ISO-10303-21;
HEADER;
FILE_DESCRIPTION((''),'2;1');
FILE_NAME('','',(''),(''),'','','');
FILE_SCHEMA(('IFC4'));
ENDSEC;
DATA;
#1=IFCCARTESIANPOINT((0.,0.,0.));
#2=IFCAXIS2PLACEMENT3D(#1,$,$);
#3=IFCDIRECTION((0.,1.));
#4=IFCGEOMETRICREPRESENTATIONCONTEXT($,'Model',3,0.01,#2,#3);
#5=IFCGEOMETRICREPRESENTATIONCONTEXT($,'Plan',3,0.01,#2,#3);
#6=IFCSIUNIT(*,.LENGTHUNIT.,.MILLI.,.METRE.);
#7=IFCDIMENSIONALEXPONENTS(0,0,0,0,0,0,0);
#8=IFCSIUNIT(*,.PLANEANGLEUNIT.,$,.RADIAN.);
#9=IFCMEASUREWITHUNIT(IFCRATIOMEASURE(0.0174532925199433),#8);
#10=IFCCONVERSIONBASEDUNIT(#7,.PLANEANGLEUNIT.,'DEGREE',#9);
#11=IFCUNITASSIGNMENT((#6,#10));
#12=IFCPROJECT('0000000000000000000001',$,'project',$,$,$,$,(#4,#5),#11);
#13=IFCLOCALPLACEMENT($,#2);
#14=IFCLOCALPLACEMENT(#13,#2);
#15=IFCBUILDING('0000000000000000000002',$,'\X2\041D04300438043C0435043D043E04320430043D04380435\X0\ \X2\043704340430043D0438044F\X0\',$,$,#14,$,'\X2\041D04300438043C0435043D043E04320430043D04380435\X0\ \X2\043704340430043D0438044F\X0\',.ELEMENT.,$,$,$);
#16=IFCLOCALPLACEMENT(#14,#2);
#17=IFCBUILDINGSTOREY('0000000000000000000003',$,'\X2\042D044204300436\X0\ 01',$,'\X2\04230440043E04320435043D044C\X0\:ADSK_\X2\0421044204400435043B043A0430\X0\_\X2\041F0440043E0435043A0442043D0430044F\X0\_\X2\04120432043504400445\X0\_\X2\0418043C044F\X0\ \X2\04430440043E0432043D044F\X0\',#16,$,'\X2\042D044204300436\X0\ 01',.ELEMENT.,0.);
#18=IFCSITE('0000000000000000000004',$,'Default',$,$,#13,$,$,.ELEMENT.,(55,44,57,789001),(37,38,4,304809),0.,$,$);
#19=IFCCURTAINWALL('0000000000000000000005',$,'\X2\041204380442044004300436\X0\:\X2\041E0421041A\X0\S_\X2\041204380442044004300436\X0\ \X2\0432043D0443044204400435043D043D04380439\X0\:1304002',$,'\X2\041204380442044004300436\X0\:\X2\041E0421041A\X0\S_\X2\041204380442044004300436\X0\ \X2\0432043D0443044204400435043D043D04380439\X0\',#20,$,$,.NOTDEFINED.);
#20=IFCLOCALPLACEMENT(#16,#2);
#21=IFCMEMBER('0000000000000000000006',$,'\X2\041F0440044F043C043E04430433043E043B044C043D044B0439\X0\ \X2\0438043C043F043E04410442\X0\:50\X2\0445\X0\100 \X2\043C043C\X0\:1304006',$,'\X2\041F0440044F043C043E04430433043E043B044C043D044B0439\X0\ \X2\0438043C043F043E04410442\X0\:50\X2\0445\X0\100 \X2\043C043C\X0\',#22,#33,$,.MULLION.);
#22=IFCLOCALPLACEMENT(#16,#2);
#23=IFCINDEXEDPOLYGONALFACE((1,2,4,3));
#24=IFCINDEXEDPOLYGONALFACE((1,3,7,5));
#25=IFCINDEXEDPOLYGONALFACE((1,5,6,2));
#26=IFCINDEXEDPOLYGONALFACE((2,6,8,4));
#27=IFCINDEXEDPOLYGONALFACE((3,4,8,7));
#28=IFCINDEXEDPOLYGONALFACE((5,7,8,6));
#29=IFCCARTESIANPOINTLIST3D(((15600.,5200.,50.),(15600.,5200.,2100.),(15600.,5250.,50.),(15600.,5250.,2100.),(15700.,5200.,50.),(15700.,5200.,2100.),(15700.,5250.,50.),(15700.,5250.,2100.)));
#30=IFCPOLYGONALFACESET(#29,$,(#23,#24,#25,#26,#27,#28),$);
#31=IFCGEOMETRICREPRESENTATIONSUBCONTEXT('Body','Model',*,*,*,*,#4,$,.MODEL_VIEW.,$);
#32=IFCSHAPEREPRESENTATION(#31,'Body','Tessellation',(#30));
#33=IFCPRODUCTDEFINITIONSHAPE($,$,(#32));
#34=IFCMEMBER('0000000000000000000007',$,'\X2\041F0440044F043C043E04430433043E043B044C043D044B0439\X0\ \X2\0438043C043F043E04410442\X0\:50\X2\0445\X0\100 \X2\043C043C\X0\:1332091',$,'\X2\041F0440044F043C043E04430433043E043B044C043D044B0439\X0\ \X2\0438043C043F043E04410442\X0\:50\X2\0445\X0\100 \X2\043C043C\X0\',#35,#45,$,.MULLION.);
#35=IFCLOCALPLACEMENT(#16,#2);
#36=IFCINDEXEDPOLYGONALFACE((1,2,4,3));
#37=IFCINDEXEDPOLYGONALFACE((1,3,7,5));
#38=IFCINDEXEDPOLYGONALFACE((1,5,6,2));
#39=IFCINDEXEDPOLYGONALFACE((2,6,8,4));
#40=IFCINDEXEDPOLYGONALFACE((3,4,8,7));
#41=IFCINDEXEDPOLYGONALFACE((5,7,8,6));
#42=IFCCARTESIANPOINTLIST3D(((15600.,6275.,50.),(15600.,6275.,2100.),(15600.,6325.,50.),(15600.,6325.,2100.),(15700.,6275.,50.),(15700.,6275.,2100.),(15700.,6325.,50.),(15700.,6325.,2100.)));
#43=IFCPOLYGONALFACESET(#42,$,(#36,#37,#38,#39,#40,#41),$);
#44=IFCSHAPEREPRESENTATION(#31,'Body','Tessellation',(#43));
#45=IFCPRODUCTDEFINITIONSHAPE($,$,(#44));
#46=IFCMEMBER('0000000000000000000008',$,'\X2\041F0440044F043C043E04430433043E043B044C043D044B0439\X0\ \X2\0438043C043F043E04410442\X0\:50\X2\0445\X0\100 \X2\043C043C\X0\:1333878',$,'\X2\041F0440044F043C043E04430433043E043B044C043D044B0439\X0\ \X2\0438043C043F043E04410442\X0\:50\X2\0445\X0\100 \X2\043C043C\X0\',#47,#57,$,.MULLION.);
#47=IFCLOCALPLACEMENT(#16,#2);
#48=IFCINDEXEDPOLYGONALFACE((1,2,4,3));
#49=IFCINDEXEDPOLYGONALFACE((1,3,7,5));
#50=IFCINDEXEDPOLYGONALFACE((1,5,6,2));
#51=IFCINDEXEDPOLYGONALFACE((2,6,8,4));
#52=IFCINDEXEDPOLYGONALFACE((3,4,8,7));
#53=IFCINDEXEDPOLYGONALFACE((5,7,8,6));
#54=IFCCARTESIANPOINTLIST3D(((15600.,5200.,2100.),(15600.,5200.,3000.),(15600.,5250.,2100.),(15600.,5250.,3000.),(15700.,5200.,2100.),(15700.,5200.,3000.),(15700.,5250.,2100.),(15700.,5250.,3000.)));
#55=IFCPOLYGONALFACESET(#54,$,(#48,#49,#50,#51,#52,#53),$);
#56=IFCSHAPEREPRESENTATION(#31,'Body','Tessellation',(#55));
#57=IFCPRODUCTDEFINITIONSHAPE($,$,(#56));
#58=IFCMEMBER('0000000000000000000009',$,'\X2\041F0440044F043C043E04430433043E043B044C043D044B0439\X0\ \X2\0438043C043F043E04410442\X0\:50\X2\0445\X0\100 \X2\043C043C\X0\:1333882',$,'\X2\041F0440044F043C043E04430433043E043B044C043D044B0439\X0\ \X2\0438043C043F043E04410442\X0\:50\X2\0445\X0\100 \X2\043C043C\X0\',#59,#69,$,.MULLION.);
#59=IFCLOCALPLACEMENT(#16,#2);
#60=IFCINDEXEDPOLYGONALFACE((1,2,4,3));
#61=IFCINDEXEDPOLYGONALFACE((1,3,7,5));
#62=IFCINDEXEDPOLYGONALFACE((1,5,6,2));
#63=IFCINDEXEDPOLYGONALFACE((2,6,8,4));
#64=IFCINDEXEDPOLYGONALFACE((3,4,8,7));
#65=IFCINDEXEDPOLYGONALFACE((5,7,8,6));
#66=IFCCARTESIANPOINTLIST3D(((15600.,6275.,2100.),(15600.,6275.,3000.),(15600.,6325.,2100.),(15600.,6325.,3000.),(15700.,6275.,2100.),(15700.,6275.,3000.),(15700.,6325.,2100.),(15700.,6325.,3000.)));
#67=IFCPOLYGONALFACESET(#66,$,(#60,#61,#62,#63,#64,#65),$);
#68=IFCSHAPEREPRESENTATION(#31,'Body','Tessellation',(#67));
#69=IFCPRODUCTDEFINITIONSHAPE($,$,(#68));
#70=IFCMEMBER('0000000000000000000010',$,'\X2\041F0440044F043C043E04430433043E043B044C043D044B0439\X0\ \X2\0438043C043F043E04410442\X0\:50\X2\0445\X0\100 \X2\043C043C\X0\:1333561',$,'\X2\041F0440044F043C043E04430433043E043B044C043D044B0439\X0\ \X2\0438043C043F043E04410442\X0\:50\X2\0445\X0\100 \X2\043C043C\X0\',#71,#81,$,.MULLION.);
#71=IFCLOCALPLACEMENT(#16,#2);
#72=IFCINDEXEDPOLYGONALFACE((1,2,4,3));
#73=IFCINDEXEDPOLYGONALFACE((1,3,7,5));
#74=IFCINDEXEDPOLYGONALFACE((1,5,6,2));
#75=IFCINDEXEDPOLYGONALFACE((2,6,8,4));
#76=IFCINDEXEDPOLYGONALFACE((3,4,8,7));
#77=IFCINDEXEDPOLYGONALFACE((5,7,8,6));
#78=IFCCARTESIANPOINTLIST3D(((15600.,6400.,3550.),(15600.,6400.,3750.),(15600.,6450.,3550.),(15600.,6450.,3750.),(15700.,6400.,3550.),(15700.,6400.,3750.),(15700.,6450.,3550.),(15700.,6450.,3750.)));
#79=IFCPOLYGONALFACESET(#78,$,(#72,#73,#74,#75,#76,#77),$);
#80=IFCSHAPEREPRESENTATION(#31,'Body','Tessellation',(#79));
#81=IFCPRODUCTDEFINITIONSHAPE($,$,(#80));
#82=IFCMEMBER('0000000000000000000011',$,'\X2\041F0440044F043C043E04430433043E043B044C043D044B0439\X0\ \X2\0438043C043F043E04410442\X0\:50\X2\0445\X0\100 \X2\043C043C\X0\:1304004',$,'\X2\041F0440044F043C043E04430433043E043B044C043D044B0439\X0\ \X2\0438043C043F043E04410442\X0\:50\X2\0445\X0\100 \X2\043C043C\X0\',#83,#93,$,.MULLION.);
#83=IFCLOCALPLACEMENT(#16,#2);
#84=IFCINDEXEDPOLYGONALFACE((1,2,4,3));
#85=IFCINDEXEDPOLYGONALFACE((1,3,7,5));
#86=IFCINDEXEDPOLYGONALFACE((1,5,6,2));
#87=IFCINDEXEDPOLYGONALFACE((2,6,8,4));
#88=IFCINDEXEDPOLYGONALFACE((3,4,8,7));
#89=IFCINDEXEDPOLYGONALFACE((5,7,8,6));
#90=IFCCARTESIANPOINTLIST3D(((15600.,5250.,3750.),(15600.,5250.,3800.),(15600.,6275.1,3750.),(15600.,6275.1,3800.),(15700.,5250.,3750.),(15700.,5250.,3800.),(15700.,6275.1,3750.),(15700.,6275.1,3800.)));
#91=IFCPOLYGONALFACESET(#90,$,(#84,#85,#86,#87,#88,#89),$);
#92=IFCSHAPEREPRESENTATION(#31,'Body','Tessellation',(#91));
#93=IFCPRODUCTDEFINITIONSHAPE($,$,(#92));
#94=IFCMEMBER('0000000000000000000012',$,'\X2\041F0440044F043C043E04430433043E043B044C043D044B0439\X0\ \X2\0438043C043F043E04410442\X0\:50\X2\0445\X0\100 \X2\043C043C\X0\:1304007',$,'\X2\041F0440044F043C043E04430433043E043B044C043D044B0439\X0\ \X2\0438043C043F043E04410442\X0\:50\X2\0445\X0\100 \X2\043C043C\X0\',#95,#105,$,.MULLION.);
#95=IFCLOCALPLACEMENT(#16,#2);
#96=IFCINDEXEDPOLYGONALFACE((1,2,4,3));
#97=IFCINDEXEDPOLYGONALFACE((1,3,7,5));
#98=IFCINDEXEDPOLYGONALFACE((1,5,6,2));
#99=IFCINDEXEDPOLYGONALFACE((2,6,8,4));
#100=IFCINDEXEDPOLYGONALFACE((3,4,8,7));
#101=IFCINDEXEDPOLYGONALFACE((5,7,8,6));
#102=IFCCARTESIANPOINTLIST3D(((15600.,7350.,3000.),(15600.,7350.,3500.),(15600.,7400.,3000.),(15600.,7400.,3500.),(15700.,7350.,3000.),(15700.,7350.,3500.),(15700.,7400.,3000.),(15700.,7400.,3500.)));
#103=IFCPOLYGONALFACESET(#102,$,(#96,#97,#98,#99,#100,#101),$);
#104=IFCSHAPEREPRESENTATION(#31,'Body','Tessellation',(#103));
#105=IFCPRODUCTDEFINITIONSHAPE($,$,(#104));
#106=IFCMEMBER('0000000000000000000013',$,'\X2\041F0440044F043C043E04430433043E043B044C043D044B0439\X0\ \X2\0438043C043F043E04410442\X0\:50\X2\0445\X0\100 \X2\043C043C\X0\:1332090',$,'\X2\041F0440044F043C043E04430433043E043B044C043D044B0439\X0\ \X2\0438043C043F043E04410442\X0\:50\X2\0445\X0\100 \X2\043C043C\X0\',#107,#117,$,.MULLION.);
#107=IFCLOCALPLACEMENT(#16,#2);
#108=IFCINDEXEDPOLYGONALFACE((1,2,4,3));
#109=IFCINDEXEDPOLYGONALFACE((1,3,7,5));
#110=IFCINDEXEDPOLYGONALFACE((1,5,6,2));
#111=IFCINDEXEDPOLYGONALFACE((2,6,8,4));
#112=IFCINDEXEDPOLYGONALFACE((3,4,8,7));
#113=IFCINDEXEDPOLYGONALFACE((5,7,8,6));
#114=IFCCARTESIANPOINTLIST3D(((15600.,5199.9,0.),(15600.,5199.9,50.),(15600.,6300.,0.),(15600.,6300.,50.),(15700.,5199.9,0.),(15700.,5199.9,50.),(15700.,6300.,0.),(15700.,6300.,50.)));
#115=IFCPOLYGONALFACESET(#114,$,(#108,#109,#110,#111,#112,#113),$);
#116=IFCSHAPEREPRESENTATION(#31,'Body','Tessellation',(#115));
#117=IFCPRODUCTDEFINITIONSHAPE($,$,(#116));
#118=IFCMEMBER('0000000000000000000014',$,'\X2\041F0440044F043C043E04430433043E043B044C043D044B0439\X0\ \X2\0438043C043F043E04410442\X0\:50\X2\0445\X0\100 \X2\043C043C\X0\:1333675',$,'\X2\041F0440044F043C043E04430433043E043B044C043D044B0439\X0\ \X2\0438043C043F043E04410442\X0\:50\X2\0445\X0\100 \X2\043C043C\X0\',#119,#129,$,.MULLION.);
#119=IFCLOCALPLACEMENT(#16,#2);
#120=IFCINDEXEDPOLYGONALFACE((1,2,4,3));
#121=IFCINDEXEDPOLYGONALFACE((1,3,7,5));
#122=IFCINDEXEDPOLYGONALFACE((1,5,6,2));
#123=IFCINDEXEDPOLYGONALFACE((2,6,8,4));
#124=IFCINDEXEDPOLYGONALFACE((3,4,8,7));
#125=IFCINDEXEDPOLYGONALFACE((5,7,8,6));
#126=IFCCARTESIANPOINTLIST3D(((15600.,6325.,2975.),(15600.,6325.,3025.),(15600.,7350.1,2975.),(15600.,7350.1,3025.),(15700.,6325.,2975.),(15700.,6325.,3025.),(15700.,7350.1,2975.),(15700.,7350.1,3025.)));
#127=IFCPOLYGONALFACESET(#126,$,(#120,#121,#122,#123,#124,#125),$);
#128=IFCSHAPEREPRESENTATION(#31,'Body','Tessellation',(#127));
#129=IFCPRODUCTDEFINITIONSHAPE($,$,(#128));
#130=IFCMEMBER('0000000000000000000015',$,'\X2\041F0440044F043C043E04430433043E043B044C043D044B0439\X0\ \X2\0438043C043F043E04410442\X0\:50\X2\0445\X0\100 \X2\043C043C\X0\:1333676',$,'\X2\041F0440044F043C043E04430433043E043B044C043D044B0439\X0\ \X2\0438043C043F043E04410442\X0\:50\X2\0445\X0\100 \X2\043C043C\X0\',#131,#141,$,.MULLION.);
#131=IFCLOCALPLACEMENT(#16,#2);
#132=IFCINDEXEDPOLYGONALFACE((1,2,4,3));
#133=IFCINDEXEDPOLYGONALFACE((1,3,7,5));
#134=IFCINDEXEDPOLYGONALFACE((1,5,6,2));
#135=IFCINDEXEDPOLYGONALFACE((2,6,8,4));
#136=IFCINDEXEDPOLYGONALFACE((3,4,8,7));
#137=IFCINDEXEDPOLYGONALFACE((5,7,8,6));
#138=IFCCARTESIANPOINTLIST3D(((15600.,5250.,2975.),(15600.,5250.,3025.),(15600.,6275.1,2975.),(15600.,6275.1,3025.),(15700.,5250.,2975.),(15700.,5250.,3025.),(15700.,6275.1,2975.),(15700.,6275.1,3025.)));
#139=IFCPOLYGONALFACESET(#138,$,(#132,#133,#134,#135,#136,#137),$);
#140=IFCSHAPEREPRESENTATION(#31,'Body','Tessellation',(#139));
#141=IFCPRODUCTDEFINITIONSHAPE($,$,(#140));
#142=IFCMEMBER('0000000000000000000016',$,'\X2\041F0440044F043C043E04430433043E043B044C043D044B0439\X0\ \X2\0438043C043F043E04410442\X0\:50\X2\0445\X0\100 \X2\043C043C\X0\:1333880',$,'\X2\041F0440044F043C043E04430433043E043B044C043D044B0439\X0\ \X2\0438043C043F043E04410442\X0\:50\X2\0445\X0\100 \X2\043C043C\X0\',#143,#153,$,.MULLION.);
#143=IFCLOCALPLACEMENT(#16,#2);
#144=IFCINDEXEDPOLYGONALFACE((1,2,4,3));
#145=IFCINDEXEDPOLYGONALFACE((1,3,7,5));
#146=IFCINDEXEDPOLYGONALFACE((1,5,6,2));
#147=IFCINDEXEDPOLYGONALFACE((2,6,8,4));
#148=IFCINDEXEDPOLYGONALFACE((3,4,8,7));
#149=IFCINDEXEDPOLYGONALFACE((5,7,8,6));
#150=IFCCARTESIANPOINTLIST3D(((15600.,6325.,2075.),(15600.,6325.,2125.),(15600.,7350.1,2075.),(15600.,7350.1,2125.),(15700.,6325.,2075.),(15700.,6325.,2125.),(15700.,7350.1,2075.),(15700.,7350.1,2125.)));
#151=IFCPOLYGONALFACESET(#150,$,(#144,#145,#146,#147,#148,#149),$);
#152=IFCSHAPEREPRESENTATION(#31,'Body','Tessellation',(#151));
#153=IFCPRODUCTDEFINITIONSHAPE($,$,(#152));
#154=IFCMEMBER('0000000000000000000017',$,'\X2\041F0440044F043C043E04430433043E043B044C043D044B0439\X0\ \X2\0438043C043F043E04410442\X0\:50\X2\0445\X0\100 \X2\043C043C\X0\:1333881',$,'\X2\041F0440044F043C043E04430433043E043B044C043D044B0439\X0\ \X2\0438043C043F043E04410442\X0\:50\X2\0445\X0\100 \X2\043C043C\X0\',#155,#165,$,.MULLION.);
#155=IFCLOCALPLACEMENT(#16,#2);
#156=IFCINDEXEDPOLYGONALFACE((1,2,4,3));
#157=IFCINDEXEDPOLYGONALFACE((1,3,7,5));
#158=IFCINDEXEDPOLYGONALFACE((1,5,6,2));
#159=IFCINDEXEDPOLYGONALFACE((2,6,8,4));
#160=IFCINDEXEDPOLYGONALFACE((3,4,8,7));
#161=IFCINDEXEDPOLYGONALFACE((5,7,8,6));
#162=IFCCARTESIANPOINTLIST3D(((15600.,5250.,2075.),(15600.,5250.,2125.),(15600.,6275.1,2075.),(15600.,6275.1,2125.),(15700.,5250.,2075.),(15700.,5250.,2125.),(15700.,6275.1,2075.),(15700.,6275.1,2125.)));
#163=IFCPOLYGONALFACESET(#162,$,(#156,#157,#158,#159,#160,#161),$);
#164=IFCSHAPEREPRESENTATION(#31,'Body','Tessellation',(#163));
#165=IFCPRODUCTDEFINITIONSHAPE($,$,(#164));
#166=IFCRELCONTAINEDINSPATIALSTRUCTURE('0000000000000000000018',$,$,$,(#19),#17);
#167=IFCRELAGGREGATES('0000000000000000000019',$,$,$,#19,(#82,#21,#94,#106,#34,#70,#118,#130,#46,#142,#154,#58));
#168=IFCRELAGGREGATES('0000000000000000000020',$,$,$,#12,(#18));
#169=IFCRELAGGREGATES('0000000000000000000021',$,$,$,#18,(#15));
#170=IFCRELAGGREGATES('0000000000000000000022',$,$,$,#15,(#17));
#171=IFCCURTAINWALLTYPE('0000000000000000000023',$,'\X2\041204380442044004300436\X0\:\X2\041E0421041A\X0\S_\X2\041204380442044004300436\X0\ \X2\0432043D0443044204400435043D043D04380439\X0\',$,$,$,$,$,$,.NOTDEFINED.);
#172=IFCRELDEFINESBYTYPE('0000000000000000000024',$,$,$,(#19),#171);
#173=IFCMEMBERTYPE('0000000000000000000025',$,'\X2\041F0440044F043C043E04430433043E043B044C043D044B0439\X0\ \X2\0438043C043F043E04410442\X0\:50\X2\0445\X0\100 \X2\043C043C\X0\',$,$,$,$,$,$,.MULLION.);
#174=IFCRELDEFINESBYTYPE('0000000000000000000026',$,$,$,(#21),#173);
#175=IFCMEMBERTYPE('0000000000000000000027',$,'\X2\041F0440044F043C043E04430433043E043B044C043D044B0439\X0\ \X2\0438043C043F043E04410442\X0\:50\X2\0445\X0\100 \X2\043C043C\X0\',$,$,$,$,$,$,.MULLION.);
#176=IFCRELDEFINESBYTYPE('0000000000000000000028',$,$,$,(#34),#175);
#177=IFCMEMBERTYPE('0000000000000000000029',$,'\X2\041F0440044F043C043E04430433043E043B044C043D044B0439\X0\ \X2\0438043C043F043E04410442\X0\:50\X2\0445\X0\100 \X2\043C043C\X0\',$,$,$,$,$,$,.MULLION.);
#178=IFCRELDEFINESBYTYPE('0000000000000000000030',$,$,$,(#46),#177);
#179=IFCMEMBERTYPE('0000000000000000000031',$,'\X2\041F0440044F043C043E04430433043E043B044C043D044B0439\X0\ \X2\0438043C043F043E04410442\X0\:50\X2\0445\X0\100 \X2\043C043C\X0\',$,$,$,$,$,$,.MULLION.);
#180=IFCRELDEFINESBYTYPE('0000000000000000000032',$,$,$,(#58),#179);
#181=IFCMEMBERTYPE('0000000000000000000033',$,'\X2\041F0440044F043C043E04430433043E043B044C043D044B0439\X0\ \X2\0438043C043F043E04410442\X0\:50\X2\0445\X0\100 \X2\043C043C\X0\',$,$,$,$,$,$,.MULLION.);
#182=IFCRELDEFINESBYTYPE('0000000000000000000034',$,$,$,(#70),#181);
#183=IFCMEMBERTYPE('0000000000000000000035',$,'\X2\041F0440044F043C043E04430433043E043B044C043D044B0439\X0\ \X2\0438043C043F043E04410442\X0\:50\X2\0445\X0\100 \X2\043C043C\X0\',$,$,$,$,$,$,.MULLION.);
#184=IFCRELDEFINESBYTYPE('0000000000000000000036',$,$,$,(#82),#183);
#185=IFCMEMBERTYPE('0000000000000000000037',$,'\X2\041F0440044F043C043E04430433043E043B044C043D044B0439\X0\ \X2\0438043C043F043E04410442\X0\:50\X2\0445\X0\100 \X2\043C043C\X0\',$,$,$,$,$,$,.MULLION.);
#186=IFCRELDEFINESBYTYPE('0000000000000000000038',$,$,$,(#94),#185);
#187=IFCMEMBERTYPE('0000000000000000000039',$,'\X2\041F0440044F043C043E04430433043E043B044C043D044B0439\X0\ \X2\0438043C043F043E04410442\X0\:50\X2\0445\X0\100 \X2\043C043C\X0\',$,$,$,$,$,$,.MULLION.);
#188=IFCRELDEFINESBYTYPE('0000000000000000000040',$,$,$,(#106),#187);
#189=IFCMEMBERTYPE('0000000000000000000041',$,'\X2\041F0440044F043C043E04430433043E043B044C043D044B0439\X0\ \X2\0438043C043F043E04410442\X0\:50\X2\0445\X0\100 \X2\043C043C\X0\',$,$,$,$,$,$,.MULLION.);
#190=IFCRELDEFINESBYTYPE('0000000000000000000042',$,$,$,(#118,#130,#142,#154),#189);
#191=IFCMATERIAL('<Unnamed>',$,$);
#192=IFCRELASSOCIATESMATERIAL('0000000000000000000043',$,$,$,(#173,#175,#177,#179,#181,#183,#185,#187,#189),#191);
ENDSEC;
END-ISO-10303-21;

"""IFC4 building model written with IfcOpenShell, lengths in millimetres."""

from ifc_helpers import new_model, entity, si_unit, converted_unit, direction, frame, origin, place, context, subcontext, project, spatial, indexed_curve, outline, extrude, source, transform, mapped, material, type_object, type_shapes, element, aggregate, save


model = new_model("IFC4")

# Units and contexts
model_context = context("Model", 3, precision=0.01, world=origin(), true_north=direction((0.0, 1.0)))
plan_context = context("Plan", 3, precision=0.01, world=origin(), true_north=direction((0.0, 1.0)))
body_context = subcontext(model_context, "Body", "Model", "MODEL_VIEW")
ifc_project = project(units=[si_unit("LENGTHUNIT", "METRE", prefix="MILLI"), converted_unit("PLANEANGLEUNIT", "DEGREE", entity("IfcRatioMeasure", 0.0174532925199433), si_unit("PLANEANGLEUNIT", "RADIAN"), dimensions=[0, 0, 0, 0, 0, 0, 0])], contexts=[model_context, plan_context])

# Site, building, storey
site_placement = place(None, frame((0.0, 0.0, 0.0)))
site = spatial("IfcSite", under=ifc_project, at=site_placement, Name="Default", CompositionType="ELEMENT", RefLatitude=(55, 44, 57, 789001), RefLongitude=(37, 38, 4, 304809), RefElevation=0.0)
building_placement = place(site_placement, origin())
building = spatial("IfcBuilding", under=site, at=building_placement, Name="Наименование здания", LongName="Наименование здания", CompositionType="ELEMENT")
storey_placement = place(building_placement, origin())
storey = spatial("IfcBuildingStorey", under=building, at=storey_placement, Name="Этаж 01", ObjectType="Уровень:ADSK_Стрелка_Проектная_Вверх_Имя уровня", LongName="Этаж 01", CompositionType="ELEMENT", Elevation=0.0)

# Curtain wall, members
curtain_wall_type = type_object("IfcCurtainWallType", Name="Витраж:ОСКS_Витраж внутренний", PredefinedType="NOTDEFINED")
curtain_wall_placement = place(storey_placement, origin())
curtain_wall = element("IfcCurtainWall", 1, at=curtain_wall_placement, inside=storey, type_object=curtain_wall_type, Name="Витраж:ОСКS_Витраж внутренний:1304002", ObjectType="Витраж:ОСКS_Витраж внутренний", PredefinedType="NOTDEFINED")
ifc_material_1 = material(Name="<Unnamed>")
member_type_1 = type_object("IfcMemberType", Name="Прямоугольный импост:50х100 мм", PredefinedType="MULLION", material=ifc_material_1)
shared_shape_1 = source(origin(), body_context, "Body", "SweptSolid", [
    extrude(outline(indexed_curve([(-50.0, -25.0), (50.0, -25.0), (50.0, 25.0), (-50.0, 25.0), (-50.0, -25.0)], self_intersect=False)), frame((-25.0, 0.0, -2050.0), z_axis=(0.0, 0.0, 1.0), x_axis=(0.0, -1.0, 0.0)), (0.0, 0.0, 1.0), 2050.0),
])
type_shapes(member_type_1, [shared_shape_1])
member_1_placement = place(storey_placement, frame((15650.0, 5200.0, 50.0), z_axis=(0.0, 0.0, -1.0), x_axis=(0.0, -1.0, 0.0)))
member_1 = element("IfcMember", 2, at=member_1_placement, type_object=member_type_1, Name="Прямоугольный импост:50х100 мм:1304006", ObjectType="Прямоугольный импост:50х100 мм", PredefinedType="MULLION", context=body_context, shape_type="MappedRepresentation", body=[
    mapped(shared_shape_1, transform((0.0, 0.0, 0.0), scale=1.0)),
])
member_type_2 = type_object("IfcMemberType", Name="Прямоугольный импост:50х100 мм", PredefinedType="MULLION", material=ifc_material_1)
shared_shape_2 = source(origin(), body_context, "Body", "SweptSolid", [
    extrude(outline(indexed_curve([(-50.0, -25.0), (50.0, -25.0), (50.0, 25.0), (-50.0, 25.0), (-50.0, -25.0)], self_intersect=False)), frame((0.0, 0.0, -2050.0), z_axis=(0.0, 0.0, 1.0), x_axis=(0.0, -1.0, 0.0)), (0.0, 0.0, 1.0), 2050.0),
])
type_shapes(member_type_2, [shared_shape_2])
member_2_placement = place(storey_placement, frame((15650.0, 6300.0, 50.0), z_axis=(0.0, 0.0, -1.0), x_axis=(0.0, -1.0, 0.0)))
member_2 = element("IfcMember", 3, at=member_2_placement, type_object=member_type_2, Name="Прямоугольный импост:50х100 мм:1332091", ObjectType="Прямоугольный импост:50х100 мм", PredefinedType="MULLION", context=body_context, shape_type="MappedRepresentation", body=[
    mapped(shared_shape_2, transform((0.0, 0.0, 0.0), scale=1.0)),
])
member_type_3 = type_object("IfcMemberType", Name="Прямоугольный импост:50х100 мм", PredefinedType="MULLION", material=ifc_material_1)
shared_shape_3 = source(origin(), body_context, "Body", "SweptSolid", [
    extrude(outline(indexed_curve([(-50.0, -25.0), (50.0, -25.0), (50.0, 25.0), (-50.0, 25.0), (-50.0, -25.0)], self_intersect=False)), frame((-25.0, 0.0, -900.0), z_axis=(0.0, 0.0, 1.0), x_axis=(0.0, -1.0, 0.0)), (0.0, 0.0, 1.0), 900.0),
])
type_shapes(member_type_3, [shared_shape_3])
member_3_placement = place(storey_placement, frame((15650.0, 5200.0, 2100.0), z_axis=(0.0, 0.0, -1.0), x_axis=(0.0, -1.0, 0.0)))
member_3 = element("IfcMember", 4, at=member_3_placement, type_object=member_type_3, Name="Прямоугольный импост:50х100 мм:1333878", ObjectType="Прямоугольный импост:50х100 мм", PredefinedType="MULLION", context=body_context, shape_type="MappedRepresentation", body=[
    mapped(shared_shape_3, transform((0.0, 0.0, 0.0), scale=1.0)),
])
member_type_4 = type_object("IfcMemberType", Name="Прямоугольный импост:50х100 мм", PredefinedType="MULLION", material=ifc_material_1)
shared_shape_4 = source(origin(), body_context, "Body", "SweptSolid", [
    extrude(outline(indexed_curve([(-50.0, -25.0), (50.0, -25.0), (50.0, 25.0), (-50.0, 25.0), (-50.0, -25.0)], self_intersect=False)), frame((0.0, 0.0, -900.0), z_axis=(0.0, 0.0, 1.0), x_axis=(0.0, -1.0, 0.0)), (0.0, 0.0, 1.0), 900.0),
])
type_shapes(member_type_4, [shared_shape_4])
member_4_placement = place(storey_placement, frame((15650.0, 6300.0, 2100.0), z_axis=(0.0, 0.0, -1.0), x_axis=(0.0, -1.0, 0.0)))
member_4 = element("IfcMember", 5, at=member_4_placement, type_object=member_type_4, Name="Прямоугольный импост:50х100 мм:1333882", ObjectType="Прямоугольный импост:50х100 мм", PredefinedType="MULLION", context=body_context, shape_type="MappedRepresentation", body=[
    mapped(shared_shape_4, transform((0.0, 0.0, 0.0), scale=1.0)),
])
member_type_5 = type_object("IfcMemberType", Name="Прямоугольный импост:50х100 мм", PredefinedType="MULLION", material=ifc_material_1)
shared_shape_5 = source(origin(), body_context, "Body", "SweptSolid", [
    extrude(outline(indexed_curve([(-50.0, -25.0), (50.0, -25.0), (50.0, 25.0), (-50.0, 25.0), (-50.0, -25.0)], self_intersect=False)), frame((-25.0, 0.0, -200.0), z_axis=(0.0, 0.0, 1.0), x_axis=(0.0, -1.0, 0.0)), (0.0, 0.0, 1.0), 200.0),
])
type_shapes(member_type_5, [shared_shape_5])
member_5_placement = place(storey_placement, frame((15650.0, 6450.0, 3750.0), z_axis=(0.0, 0.0, 1.0), x_axis=(0.0, 1.0, 0.0)))
member_5 = element("IfcMember", 6, at=member_5_placement, type_object=member_type_5, Name="Прямоугольный импост:50х100 мм:1333561", ObjectType="Прямоугольный импост:50х100 мм", PredefinedType="MULLION", context=body_context, shape_type="MappedRepresentation", body=[
    mapped(shared_shape_5, transform((0.0, 0.0, 0.0), scale=1.0)),
])
member_type_6 = type_object("IfcMemberType", Name="Прямоугольный импост:50х100 мм", PredefinedType="MULLION", material=ifc_material_1)
shared_shape_6 = source(origin(), body_context, "Body", "SweptSolid", [
    extrude(outline(indexed_curve([(-50.0, -25.0), (50.0, -25.0), (50.0, 25.0), (-50.0, 25.0), (-50.0, -25.0)], self_intersect=False)), frame((-25.0, 0.0, -1025.1), z_axis=(0.0, 0.0, 1.0), x_axis=(0.0, -1.0, 0.0)), (0.0, 0.0, 1.0), 1025.1),
])
type_shapes(member_type_6, [shared_shape_6])
member_6_placement = place(storey_placement, frame((15650.0, 5250.0, 3800.0), z_axis=(0.0, -1.0, 0.0), x_axis=(0.0, 0.0, 1.0)))
member_6 = element("IfcMember", 7, at=member_6_placement, type_object=member_type_6, Name="Прямоугольный импост:50х100 мм:1304004", ObjectType="Прямоугольный импост:50х100 мм", PredefinedType="MULLION", context=body_context, shape_type="MappedRepresentation", body=[
    mapped(shared_shape_6, transform((0.0, 0.0, 0.0), scale=1.0)),
])
member_type_7 = type_object("IfcMemberType", Name="Прямоугольный импост:50х100 мм", PredefinedType="MULLION", material=ifc_material_1)
shared_shape_7 = source(origin(), body_context, "Body", "SweptSolid", [
    extrude(outline(indexed_curve([(-50.0, -25.0), (50.0, -25.0), (50.0, 25.0), (-50.0, 25.0), (-50.0, -25.0)], self_intersect=False)), frame((-25.0, 0.0, -500.0), z_axis=(0.0, 0.0, 1.0), x_axis=(0.0, -1.0, 0.0)), (0.0, 0.0, 1.0), 500.0),
])
type_shapes(member_type_7, [shared_shape_7])
member_7_placement = place(storey_placement, frame((15650.0, 7400.0, 3500.0), z_axis=(0.0, 0.0, 1.0), x_axis=(0.0, 1.0, 0.0)))
member_7 = element("IfcMember", 8, at=member_7_placement, type_object=member_type_7, Name="Прямоугольный импост:50х100 мм:1304007", ObjectType="Прямоугольный импост:50х100 мм", PredefinedType="MULLION", context=body_context, shape_type="MappedRepresentation", body=[
    mapped(shared_shape_7, transform((0.0, 0.0, 0.0), scale=1.0)),
])
member_type_8 = type_object("IfcMemberType", Name="Прямоугольный импост:50х100 мм", PredefinedType="MULLION", material=ifc_material_1)
shared_shape_8 = source(origin(), body_context, "Body", "SweptSolid", [
    extrude(outline(indexed_curve([(-50.0, -25.0), (50.0, -25.0), (50.0, 25.0), (-50.0, 25.0), (-50.0, -25.0)], self_intersect=False)), frame((-25.0, 0.0, -1100.1), z_axis=(0.0, 0.0, 1.0), x_axis=(0.0, -1.0, 0.0)), (0.0, 0.0, 1.0), 1100.1),
])
type_shapes(member_type_8, [shared_shape_8])
member_8_placement = place(storey_placement, frame((15650.0, 6300.0, 0.0), z_axis=(0.0, 1.0, 0.0), x_axis=(0.0, 0.0, -1.0)))
member_8 = element("IfcMember", 9, at=member_8_placement, type_object=member_type_8, Name="Прямоугольный импост:50х100 мм:1332090", ObjectType="Прямоугольный импост:50х100 мм", PredefinedType="MULLION", context=body_context, shape_type="MappedRepresentation", body=[
    mapped(shared_shape_8, transform((0.0, 0.0, 0.0), scale=1.0)),
])
member_type_9 = type_object("IfcMemberType", Name="Прямоугольный импост:50х100 мм", PredefinedType="MULLION", material=ifc_material_1)
shared_shape_9 = source(origin(), body_context, "Body", "SweptSolid", [
    extrude(outline(indexed_curve([(-50.0, -25.0), (50.0, -25.0), (50.0, 25.0), (-50.0, 25.0), (-50.0, -25.0)], self_intersect=False)), frame((0.0, 0.0, -1025.1), z_axis=(0.0, 0.0, 1.0), x_axis=(0.0, -1.0, 0.0)), (0.0, 0.0, 1.0), 1025.1),
])
type_shapes(member_type_9, [shared_shape_9])
member_9_placement = place(storey_placement, frame((15650.0, 6325.0, 3000.0), z_axis=(0.0, -1.0, 0.0), x_axis=(0.0, 0.0, 1.0)))
member_9 = element("IfcMember", 10, at=member_9_placement, type_object=member_type_9, Name="Прямоугольный импост:50х100 мм:1333675", ObjectType="Прямоугольный импост:50х100 мм", PredefinedType="MULLION", context=body_context, shape_type="MappedRepresentation", body=[
    mapped(shared_shape_9, transform((0.0, 0.0, 0.0), scale=1.0)),
])
member_10_placement = place(storey_placement, frame((15650.0, 5250.0, 3000.0), z_axis=(0.0, -1.0, 0.0), x_axis=(0.0, 0.0, 1.0)))
member_10 = element("IfcMember", 11, at=member_10_placement, type_object=member_type_9, Name="Прямоугольный импост:50х100 мм:1333676", ObjectType="Прямоугольный импост:50х100 мм", PredefinedType="MULLION", context=body_context, shape_type="MappedRepresentation", body=[
    mapped(shared_shape_9, transform((0.0, 0.0, 0.0), scale=1.0)),
])
member_11_placement = place(storey_placement, frame((15650.0, 6325.0, 2100.0), z_axis=(0.0, -1.0, 0.0), x_axis=(0.0, 0.0, 1.0)))
member_11 = element("IfcMember", 12, at=member_11_placement, type_object=member_type_9, Name="Прямоугольный импост:50х100 мм:1333880", ObjectType="Прямоугольный импост:50х100 мм", PredefinedType="MULLION", context=body_context, shape_type="MappedRepresentation", body=[
    mapped(shared_shape_9, transform((0.0, 0.0, 0.0), scale=1.0)),
])
member_12_placement = place(storey_placement, frame((15650.0, 5250.0, 2100.0), z_axis=(0.0, -1.0, 0.0), x_axis=(0.0, 0.0, 1.0)))
member_12 = element("IfcMember", 13, at=member_12_placement, type_object=member_type_9, Name="Прямоугольный импост:50х100 мм:1333881", ObjectType="Прямоугольный импост:50х100 мм", PredefinedType="MULLION", context=body_context, shape_type="MappedRepresentation", body=[
    mapped(shared_shape_9, transform((0.0, 0.0, 0.0), scale=1.0)),
])
aggregate(curtain_wall, [member_6, member_1, member_7, member_8, member_2, member_5, member_9, member_10, member_3, member_11, member_12, member_4])

save(model, "model.ifc")
